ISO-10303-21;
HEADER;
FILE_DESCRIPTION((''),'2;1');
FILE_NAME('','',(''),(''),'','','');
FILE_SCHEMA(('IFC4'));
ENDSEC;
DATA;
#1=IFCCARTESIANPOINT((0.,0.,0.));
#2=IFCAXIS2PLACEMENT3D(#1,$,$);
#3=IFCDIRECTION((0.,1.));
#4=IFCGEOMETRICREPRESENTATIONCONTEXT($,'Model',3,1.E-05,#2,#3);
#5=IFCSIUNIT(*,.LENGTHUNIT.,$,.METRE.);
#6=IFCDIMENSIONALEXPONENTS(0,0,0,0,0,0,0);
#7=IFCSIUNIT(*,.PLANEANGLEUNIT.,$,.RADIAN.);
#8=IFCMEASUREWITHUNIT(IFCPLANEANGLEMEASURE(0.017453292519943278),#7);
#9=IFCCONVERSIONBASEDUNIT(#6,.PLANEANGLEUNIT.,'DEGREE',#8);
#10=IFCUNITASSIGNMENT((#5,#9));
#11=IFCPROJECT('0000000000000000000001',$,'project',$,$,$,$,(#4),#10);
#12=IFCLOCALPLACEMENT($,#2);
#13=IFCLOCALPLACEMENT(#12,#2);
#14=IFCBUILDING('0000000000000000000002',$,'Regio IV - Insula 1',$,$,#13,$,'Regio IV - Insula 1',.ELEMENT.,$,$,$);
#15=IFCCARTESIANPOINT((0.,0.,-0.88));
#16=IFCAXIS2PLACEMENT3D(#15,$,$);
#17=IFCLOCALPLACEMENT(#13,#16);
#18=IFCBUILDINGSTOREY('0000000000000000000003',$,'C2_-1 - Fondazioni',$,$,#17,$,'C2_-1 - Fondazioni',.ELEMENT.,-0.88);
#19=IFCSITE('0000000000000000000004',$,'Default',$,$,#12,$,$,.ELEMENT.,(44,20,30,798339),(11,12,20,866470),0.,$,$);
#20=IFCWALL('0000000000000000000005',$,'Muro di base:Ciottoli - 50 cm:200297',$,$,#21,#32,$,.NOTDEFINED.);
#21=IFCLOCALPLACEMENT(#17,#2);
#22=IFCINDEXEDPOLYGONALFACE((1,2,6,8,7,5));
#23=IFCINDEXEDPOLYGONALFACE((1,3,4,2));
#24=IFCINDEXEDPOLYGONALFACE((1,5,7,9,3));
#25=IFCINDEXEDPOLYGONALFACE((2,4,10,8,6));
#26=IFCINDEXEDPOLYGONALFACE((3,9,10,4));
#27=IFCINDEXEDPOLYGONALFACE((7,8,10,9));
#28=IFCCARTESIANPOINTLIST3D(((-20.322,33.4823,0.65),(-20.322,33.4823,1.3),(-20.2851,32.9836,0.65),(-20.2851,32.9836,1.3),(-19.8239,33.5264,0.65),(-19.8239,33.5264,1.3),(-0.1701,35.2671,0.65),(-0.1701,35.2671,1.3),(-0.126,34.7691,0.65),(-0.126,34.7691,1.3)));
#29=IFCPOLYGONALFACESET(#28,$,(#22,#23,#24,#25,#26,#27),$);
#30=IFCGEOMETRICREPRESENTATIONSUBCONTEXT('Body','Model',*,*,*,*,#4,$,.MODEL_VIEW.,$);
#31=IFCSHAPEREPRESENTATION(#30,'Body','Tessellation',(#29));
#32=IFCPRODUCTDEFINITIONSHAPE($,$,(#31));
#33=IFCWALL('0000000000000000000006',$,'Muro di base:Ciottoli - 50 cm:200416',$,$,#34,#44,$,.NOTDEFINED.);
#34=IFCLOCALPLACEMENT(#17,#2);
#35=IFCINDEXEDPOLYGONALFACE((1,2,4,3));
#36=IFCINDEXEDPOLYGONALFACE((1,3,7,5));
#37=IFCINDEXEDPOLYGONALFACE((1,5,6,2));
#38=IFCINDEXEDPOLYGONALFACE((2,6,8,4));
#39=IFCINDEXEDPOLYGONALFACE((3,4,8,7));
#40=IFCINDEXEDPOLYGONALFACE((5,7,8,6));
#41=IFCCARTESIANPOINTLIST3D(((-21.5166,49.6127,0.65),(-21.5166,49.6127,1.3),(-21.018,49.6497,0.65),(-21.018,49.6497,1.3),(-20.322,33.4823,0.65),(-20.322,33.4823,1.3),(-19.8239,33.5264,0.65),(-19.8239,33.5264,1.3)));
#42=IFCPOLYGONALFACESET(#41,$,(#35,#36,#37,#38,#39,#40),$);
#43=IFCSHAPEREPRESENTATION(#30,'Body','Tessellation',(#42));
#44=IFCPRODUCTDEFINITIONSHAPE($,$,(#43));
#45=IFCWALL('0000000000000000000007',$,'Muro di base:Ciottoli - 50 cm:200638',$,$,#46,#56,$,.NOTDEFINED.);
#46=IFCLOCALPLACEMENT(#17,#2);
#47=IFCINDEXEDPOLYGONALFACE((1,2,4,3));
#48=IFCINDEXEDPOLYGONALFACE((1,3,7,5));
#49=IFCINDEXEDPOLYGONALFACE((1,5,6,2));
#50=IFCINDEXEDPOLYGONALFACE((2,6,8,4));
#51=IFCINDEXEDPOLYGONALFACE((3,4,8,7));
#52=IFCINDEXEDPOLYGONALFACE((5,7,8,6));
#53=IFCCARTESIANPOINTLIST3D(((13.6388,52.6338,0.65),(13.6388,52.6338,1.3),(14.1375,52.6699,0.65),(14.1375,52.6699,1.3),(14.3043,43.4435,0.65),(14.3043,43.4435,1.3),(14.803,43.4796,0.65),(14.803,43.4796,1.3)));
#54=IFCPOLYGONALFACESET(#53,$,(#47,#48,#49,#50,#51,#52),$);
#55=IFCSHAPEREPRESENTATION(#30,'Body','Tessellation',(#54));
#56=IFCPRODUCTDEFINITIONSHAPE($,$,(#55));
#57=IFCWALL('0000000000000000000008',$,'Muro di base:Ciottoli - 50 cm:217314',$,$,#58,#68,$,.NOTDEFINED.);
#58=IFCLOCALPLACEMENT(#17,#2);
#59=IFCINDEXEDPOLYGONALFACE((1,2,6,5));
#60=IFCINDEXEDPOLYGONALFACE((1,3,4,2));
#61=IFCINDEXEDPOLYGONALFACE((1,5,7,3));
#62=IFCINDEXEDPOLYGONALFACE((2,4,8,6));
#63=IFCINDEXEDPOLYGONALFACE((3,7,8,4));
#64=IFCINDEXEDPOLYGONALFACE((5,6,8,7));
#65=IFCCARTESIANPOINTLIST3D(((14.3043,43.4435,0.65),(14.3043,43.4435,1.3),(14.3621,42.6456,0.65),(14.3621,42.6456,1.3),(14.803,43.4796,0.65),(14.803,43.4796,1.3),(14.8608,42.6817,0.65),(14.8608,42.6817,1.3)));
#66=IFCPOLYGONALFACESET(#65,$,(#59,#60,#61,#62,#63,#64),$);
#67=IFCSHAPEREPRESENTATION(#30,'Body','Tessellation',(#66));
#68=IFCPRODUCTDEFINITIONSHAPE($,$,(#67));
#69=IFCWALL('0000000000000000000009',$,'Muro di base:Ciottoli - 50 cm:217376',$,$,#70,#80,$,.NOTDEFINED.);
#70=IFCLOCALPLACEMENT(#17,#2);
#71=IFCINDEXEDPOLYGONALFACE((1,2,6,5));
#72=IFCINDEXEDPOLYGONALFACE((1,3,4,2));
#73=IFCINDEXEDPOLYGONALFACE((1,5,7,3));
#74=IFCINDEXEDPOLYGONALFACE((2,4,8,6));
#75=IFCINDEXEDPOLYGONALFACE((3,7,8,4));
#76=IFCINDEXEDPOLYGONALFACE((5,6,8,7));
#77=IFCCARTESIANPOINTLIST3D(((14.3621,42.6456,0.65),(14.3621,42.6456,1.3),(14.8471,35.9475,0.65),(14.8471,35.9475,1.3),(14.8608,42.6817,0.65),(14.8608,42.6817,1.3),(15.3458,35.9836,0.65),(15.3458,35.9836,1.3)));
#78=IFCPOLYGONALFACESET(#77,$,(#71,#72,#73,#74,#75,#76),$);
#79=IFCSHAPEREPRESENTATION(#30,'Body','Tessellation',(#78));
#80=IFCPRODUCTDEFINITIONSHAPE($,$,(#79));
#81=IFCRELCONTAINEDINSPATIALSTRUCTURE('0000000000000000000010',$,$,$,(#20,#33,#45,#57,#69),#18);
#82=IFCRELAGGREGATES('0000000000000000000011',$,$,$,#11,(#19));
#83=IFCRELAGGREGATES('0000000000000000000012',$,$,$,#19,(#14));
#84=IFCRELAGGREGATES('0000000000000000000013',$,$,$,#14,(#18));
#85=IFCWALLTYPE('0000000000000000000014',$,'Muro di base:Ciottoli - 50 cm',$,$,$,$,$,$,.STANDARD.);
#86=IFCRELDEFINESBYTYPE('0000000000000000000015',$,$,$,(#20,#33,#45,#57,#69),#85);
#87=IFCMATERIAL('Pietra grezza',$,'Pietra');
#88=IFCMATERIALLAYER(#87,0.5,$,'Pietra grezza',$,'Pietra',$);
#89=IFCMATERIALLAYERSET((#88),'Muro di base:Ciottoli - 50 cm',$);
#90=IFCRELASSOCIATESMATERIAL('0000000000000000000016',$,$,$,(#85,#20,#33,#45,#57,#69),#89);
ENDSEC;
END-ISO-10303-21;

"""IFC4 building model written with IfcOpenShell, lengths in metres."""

from ifc_helpers import new_model, entity, si_unit, converted_unit, direction, frame, frame_2d, origin, place, context, subcontext, project, spatial, polyline, rectangle, outline, extrude, material, layer, layer_set, layer_usage, type_object, element, save


model = new_model("IFC4")

# Units and contexts
model_context = context("Model", 3, precision=1e-05, world=origin(), true_north=direction((0.0, 1.0)))
body_context = subcontext(model_context, "Body", "Model", "MODEL_VIEW")
ifc_project = project(units=[si_unit("LENGTHUNIT", "METRE"), converted_unit("PLANEANGLEUNIT", "DEGREE", entity("IfcPlaneAngleMeasure", 0.017453292519943278), si_unit("PLANEANGLEUNIT", "RADIAN"), dimensions=[0, 0, 0, 0, 0, 0, 0])], contexts=[model_context])

# Site, building, storey
site_placement = place(None, origin())
site = spatial("IfcSite", under=ifc_project, at=site_placement, Name="Default", CompositionType="ELEMENT", RefLatitude=(44, 20, 30, 798339), RefLongitude=(11, 12, 20, 866470), RefElevation=0.0)
building_placement = place(site_placement, origin())
building = spatial("IfcBuilding", under=site, at=building_placement, Name="Regio IV - Insula 1", LongName="Regio IV - Insula 1", CompositionType="ELEMENT")
storey_placement = place(building_placement, frame((0.0, 0.0, -0.88)))
storey = spatial("IfcBuildingStorey", under=building, at=storey_placement, Name="C2_-1 - Fondazioni", LongName="C2_-1 - Fondazioni", CompositionType="ELEMENT", Elevation=-0.88)

# Walls
ifc_material_1 = material(Name="Pietra grezza", Category="Pietra")
ifc_layer_1 = layer(ifc_material_1, 0.5, Name="Pietra grezza", Category="Pietra")
ifc_layer_set_1 = layer_set([ifc_layer_1], Name="Muro di base:Ciottoli - 50 cm")
wall_type_1 = type_object("IfcWallType", Name="Muro di base:Ciottoli - 50 cm", PredefinedType="STANDARD", material=ifc_layer_set_1)
ifc_layer_usage_1 = layer_usage(ifc_layer_set_1, "AXIS2", "NEGATIVE", 0.25)
wall_1_placement = place(storey_placement, frame((-0.148, 35.0181, 0.65), z_axis=(0.0, 0.0, 1.0), x_axis=(-0.996101, -0.088225, 0.0)))
element("IfcWall", 1, at=wall_1_placement, inside=storey, type_object=wall_type_1, material=ifc_layer_usage_1, Name="Muro di base:Ciottoli - 50 cm:200297", PredefinedType="NOTDEFINED", context=body_context, shape_type="SweptSolid", body=[
    extrude(outline(polyline([(20.2308, -0.25), (20.238, 0.25), (0.0, 0.25), (0.0, -0.25), (19.7307, -0.25), (20.2308, -0.25)])), origin(), (0.0, 0.0, 1.0), 0.65),
])
ifc_layer_usage_2 = layer_usage(ifc_layer_set_1, "AXIS2", "NEGATIVE", 0.25)
wall_2_placement = place(storey_placement, frame((-20.0727, 33.5007, 0.65), z_axis=(0.0, 0.0, 1.0), x_axis=(-0.073856, 0.997269, 0.0)))
element("IfcWall", 2, at=wall_2_placement, inside=storey, type_object=wall_type_1, material=ifc_layer_usage_2, Name="Muro di base:Ciottoli - 50 cm:200416", PredefinedType="NOTDEFINED", context=body_context, shape_type="SweptSolid", body=[
    extrude(outline(polyline([(16.1746, -0.25), (16.1746, 0.25), (0.0, 0.25), (0.0072, -0.25), (16.1746, -0.25)])), origin(), (0.0, 0.0, 1.0), 0.65),
])
ifc_layer_usage_3 = layer_usage(ifc_layer_set_1, "AXIS2", "NEGATIVE", 0.25)
wall_3_placement = place(storey_placement, frame((13.8882, 52.6518, 0.65), z_axis=(0.0, 0.0, 1.0), x_axis=(0.07222, -0.997389, 0.0)))
element("IfcWall", 3, at=wall_3_placement, inside=storey, type_object=wall_type_1, material=ifc_layer_usage_3, Name="Muro di base:Ciottoli - 50 cm:200638", PredefinedType="NOTDEFINED", context=body_context, shape_type="SweptSolid", body=[
    extrude(rectangle(XDim=9.2144, YDim=0.5, at=frame_2d((4.6072, 0.0), x_axis=(-1.0, 0.0))), origin(), (0.0, 0.0, 1.0), 0.65),
])
ifc_layer_usage_4 = layer_usage(ifc_layer_set_1, "AXIS2", "NEGATIVE", 0.25)
wall_4_placement = place(storey_placement, frame((14.5536, 43.4616, 0.65), z_axis=(0.0, 0.0, 1.0), x_axis=(0.07222, -0.997389, 0.0)))
element("IfcWall", 4, at=wall_4_placement, inside=storey, type_object=wall_type_1, material=ifc_layer_usage_4, Name="Muro di base:Ciottoli - 50 cm:217314", PredefinedType="NOTDEFINED", context=body_context, shape_type="SweptSolid", body=[
    extrude(rectangle(XDim=0.8, YDim=0.5, at=frame_2d((0.4, 0.0), x_axis=(-1.0, 0.0))), origin(), (0.0, 0.0, 1.0), 0.65),
])
ifc_layer_usage_5 = layer_usage(ifc_layer_set_1, "AXIS2", "NEGATIVE", 0.25)
wall_5_placement = place(storey_placement, frame((14.6114, 42.6636, 0.65), z_axis=(0.0, 0.0, 1.0), x_axis=(0.07222, -0.997389, 0.0)))
element("IfcWall", 5, at=wall_5_placement, inside=storey, type_object=wall_type_1, material=ifc_layer_usage_5, Name="Muro di base:Ciottoli - 50 cm:217376", PredefinedType="NOTDEFINED", context=body_context, shape_type="SweptSolid", body=[
    extrude(rectangle(XDim=6.7157, YDim=0.5, at=frame_2d((3.3578, 0.0), x_axis=(-1.0, 0.0))), origin(), (0.0, 0.0, 1.0), 0.65),
])

save(model, "model.ifc")
